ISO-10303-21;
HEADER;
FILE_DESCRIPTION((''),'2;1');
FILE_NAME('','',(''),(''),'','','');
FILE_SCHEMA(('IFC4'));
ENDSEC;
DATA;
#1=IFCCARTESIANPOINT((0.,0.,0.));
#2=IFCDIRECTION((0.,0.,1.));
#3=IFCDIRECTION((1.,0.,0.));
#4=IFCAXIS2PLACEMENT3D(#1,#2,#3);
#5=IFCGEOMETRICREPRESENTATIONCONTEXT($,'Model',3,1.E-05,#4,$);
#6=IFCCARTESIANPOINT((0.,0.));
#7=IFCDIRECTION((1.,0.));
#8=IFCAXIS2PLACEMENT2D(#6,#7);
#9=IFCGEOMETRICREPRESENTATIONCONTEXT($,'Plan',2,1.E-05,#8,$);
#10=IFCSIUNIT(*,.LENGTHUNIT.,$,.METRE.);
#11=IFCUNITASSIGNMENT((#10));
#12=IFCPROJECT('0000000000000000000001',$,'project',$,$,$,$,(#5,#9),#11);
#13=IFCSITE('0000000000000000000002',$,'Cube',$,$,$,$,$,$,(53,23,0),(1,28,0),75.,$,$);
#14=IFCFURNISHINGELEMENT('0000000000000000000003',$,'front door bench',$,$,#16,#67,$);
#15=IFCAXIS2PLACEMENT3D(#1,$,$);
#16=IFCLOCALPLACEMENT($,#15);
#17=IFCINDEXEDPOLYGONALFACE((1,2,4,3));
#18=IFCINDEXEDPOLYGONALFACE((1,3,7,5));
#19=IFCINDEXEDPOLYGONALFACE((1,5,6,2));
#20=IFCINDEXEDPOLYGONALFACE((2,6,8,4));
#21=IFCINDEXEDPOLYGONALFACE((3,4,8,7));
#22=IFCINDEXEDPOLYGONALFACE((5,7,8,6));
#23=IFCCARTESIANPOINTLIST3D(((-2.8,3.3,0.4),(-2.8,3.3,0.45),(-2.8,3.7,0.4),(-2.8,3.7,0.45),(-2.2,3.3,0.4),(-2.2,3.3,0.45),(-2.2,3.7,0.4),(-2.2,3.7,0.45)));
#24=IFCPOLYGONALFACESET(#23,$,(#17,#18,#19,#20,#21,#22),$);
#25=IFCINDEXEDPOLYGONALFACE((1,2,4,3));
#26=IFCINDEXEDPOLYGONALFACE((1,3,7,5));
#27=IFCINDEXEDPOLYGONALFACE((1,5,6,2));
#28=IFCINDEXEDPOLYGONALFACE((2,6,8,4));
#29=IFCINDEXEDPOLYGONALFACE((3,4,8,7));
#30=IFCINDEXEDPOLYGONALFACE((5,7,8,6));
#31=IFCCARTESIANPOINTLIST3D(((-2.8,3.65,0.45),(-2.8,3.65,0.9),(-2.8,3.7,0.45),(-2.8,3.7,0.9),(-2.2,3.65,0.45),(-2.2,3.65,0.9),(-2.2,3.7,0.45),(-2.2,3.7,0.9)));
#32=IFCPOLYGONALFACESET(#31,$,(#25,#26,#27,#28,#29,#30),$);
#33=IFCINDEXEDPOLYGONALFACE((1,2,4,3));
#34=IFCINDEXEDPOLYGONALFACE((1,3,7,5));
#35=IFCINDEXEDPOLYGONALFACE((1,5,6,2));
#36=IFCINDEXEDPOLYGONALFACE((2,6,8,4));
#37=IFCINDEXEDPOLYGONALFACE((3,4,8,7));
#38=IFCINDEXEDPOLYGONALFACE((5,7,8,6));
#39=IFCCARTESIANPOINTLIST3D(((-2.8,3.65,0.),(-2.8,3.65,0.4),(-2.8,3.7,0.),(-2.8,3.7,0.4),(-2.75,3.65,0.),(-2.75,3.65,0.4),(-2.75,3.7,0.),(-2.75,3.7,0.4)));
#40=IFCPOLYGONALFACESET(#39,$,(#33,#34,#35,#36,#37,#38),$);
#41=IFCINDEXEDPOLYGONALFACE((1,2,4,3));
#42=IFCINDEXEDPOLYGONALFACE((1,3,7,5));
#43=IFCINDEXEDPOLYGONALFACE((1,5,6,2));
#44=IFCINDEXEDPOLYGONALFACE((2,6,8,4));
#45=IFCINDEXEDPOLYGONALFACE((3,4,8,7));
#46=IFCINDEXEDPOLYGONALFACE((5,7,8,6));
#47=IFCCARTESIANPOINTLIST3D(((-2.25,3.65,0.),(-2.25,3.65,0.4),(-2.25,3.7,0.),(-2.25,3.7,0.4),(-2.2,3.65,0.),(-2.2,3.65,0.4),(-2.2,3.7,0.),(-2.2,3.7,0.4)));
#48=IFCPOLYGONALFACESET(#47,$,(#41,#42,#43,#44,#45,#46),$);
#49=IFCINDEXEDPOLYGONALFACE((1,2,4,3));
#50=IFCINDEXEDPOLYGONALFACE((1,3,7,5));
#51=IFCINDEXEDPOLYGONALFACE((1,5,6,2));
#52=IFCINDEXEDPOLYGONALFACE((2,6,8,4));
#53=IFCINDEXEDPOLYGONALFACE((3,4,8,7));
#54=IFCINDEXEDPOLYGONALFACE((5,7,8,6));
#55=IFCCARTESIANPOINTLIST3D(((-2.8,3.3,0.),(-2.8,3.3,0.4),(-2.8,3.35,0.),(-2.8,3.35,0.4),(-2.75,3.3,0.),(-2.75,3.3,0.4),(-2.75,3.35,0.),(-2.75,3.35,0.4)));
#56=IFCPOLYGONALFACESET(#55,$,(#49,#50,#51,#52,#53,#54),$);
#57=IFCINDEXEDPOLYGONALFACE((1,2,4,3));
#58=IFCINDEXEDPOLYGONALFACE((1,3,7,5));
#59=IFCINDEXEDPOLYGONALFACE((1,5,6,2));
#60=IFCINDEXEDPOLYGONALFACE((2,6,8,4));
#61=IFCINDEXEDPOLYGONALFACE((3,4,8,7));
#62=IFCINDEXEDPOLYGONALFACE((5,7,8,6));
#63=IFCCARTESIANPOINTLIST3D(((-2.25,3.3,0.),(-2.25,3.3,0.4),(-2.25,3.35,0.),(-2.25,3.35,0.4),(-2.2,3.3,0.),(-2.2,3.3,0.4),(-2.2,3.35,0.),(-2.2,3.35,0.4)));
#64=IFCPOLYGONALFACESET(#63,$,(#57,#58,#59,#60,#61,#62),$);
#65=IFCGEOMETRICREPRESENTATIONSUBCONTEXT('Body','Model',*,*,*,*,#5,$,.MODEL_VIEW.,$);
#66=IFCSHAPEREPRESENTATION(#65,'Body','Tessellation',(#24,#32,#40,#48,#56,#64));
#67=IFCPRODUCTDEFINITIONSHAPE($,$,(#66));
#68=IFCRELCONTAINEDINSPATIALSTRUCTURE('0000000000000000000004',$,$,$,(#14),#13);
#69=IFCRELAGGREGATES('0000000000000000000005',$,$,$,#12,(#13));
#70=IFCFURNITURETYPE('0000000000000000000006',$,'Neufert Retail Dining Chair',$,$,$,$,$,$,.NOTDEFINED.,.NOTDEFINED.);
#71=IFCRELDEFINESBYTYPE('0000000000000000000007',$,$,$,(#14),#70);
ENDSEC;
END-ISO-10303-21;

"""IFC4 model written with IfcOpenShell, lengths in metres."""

from ifc_helpers import new_model, entity, si_unit, frame, origin_with_axes, origin_2d_with_axis, place, context, subcontext, project, spatial, line, indexed_curve, outline, extrude, shape, source, transform, mapped, type_object, type_shapes, element, save


model = new_model("IFC4")

# Units and contexts
model_context = context("Model", 3, precision=1e-05, world=origin_with_axes())
plan_context = context("Plan", 2, precision=1e-05, world=origin_2d_with_axis())
body_context_1 = subcontext(model_context, "Body", "Model", "MODEL_VIEW")
body_context_2 = subcontext(plan_context, "Body", "Plan", "PLAN_VIEW")
ifc_project = project(units=[si_unit("LENGTHUNIT", "METRE")], contexts=[model_context, plan_context])

# Site
site = spatial("IfcSite", under=ifc_project, Name="Cube", RefLatitude=(53, 23, 0), RefLongitude=(1, 28, 0), RefElevation=75.0)

# Furnishing element
furniture_type = type_object("IfcFurnitureType", Name="Neufert Retail Dining Chair", AssemblyPlace="NOTDEFINED", PredefinedType="NOTDEFINED")
shared_shape_1 = source(origin_with_axes(), body_context_1, "Body", "SweptSolid", [
    extrude(outline(indexed_curve([(-0.3, 0.0), (0.3, 0.0), (0.3, -0.4), (-0.3, -0.4)], segments=[line(1, 2, 3, 4, 1)])), frame((0.0, 0.0, 0.45), z_axis=(0.0, 0.0, 1.0), x_axis=(1.0, 0.0, 0.0)), (0.0, 0.0, -1.0), 0.05),
    extrude(outline(indexed_curve([(-0.3, 0.0), (0.3, 0.0), (0.3, -0.05), (-0.3, -0.05)], segments=[line(1, 2, 3, 4, 1)])), frame((0.0, 0.0, 0.9), z_axis=(0.0, 0.0, 1.0), x_axis=(1.0, 0.0, 0.0)), (0.0, 0.0, -1.0), 0.45),
    extrude(outline(indexed_curve([(-0.3, 0.0), (-0.25, 0.0), (-0.25, -0.05), (-0.3, -0.05)], segments=[line(1, 2, 3, 4, 1)])), origin_with_axes(), (0.0, 0.0, 1.0), 0.4),
    extrude(outline(indexed_curve([(0.3, 0.0), (0.25, 0.0), (0.25, -0.05), (0.3, -0.05)], segments=[line(1, 2, 3, 4, 1)])), origin_with_axes(), (0.0, 0.0, 1.0), 0.4),
    extrude(outline(indexed_curve([(-0.3, -0.4), (-0.25, -0.4), (-0.25, -0.35), (-0.3, -0.35)], segments=[line(1, 2, 3, 4, 1)])), origin_with_axes(), (0.0, 0.0, 1.0), 0.4),
    extrude(outline(indexed_curve([(0.3, -0.4), (0.25, -0.4), (0.25, -0.35), (0.3, -0.35)], segments=[line(1, 2, 3, 4, 1)])), origin_with_axes(), (0.0, 0.0, 1.0), 0.4),
])
shared_shape_2 = source(origin_with_axes(), body_context_2, "Body", "Curve2D", [
    entity("IfcIndexedPolyCurve", entity("IfcCartesianPointList2D", [[-0.3, -0.4], [0.3, -0.4]])),
    entity("IfcIndexedPolyCurve", entity("IfcCartesianPointList2D", [[-0.3, -0.4], [-0.3, -0.3], [-0.2121, -0.0879], [0.0, 0.0], [0.2121, -0.0879], [0.3, -0.3], [0.3, -0.4]]), [entity("IfcLineIndex", [1, 2]), entity("IfcArcIndex", [2, 3, 4]), entity("IfcArcIndex", [4, 5, 6]), entity("IfcLineIndex", [6, 7])]),
    entity("IfcIndexedPolyCurve", entity("IfcCartesianPointList2D", [[-0.26, -0.4], [-0.26, -0.3], [-0.1838, -0.1162], [0.0, -0.04], [0.1838, -0.1162], [0.26, -0.3], [0.26, -0.4]]), [entity("IfcLineIndex", [1, 2]), entity("IfcArcIndex", [2, 3, 4]), entity("IfcArcIndex", [4, 5, 6]), entity("IfcLineIndex", [6, 7])]),
])
type_shapes(furniture_type, [shared_shape_1, shared_shape_2])
furnishing_placement = place(None, frame((-2.5, 3.7, 0.0), z_axis=(0.0, 0.0, 1.0), x_axis=(1.0, 0.0, 0.0)))
element("IfcFurnishingElement", 1, at=furnishing_placement, inside=site, type_object=furniture_type, Name="front door bench", shapes=[
    shape(body_context_1, "Body", "MappedRepresentation", [mapped(shared_shape_1, transform((0.0, 0.0, 0.0), x_axis=(1.0, 0.0, 0.0), y_axis=(0.0, 1.0, 0.0), z_axis=(0.0, 0.0, 1.0), scale=1.0))]),
    shape(body_context_2, "Body", "MappedRepresentation", [mapped(shared_shape_2, transform((0.0, 0.0, 0.0), x_axis=(1.0, 0.0, 0.0), y_axis=(0.0, 1.0, 0.0), z_axis=(0.0, 0.0, 1.0), scale=1.0))]),
])

save(model, "model.ifc")
